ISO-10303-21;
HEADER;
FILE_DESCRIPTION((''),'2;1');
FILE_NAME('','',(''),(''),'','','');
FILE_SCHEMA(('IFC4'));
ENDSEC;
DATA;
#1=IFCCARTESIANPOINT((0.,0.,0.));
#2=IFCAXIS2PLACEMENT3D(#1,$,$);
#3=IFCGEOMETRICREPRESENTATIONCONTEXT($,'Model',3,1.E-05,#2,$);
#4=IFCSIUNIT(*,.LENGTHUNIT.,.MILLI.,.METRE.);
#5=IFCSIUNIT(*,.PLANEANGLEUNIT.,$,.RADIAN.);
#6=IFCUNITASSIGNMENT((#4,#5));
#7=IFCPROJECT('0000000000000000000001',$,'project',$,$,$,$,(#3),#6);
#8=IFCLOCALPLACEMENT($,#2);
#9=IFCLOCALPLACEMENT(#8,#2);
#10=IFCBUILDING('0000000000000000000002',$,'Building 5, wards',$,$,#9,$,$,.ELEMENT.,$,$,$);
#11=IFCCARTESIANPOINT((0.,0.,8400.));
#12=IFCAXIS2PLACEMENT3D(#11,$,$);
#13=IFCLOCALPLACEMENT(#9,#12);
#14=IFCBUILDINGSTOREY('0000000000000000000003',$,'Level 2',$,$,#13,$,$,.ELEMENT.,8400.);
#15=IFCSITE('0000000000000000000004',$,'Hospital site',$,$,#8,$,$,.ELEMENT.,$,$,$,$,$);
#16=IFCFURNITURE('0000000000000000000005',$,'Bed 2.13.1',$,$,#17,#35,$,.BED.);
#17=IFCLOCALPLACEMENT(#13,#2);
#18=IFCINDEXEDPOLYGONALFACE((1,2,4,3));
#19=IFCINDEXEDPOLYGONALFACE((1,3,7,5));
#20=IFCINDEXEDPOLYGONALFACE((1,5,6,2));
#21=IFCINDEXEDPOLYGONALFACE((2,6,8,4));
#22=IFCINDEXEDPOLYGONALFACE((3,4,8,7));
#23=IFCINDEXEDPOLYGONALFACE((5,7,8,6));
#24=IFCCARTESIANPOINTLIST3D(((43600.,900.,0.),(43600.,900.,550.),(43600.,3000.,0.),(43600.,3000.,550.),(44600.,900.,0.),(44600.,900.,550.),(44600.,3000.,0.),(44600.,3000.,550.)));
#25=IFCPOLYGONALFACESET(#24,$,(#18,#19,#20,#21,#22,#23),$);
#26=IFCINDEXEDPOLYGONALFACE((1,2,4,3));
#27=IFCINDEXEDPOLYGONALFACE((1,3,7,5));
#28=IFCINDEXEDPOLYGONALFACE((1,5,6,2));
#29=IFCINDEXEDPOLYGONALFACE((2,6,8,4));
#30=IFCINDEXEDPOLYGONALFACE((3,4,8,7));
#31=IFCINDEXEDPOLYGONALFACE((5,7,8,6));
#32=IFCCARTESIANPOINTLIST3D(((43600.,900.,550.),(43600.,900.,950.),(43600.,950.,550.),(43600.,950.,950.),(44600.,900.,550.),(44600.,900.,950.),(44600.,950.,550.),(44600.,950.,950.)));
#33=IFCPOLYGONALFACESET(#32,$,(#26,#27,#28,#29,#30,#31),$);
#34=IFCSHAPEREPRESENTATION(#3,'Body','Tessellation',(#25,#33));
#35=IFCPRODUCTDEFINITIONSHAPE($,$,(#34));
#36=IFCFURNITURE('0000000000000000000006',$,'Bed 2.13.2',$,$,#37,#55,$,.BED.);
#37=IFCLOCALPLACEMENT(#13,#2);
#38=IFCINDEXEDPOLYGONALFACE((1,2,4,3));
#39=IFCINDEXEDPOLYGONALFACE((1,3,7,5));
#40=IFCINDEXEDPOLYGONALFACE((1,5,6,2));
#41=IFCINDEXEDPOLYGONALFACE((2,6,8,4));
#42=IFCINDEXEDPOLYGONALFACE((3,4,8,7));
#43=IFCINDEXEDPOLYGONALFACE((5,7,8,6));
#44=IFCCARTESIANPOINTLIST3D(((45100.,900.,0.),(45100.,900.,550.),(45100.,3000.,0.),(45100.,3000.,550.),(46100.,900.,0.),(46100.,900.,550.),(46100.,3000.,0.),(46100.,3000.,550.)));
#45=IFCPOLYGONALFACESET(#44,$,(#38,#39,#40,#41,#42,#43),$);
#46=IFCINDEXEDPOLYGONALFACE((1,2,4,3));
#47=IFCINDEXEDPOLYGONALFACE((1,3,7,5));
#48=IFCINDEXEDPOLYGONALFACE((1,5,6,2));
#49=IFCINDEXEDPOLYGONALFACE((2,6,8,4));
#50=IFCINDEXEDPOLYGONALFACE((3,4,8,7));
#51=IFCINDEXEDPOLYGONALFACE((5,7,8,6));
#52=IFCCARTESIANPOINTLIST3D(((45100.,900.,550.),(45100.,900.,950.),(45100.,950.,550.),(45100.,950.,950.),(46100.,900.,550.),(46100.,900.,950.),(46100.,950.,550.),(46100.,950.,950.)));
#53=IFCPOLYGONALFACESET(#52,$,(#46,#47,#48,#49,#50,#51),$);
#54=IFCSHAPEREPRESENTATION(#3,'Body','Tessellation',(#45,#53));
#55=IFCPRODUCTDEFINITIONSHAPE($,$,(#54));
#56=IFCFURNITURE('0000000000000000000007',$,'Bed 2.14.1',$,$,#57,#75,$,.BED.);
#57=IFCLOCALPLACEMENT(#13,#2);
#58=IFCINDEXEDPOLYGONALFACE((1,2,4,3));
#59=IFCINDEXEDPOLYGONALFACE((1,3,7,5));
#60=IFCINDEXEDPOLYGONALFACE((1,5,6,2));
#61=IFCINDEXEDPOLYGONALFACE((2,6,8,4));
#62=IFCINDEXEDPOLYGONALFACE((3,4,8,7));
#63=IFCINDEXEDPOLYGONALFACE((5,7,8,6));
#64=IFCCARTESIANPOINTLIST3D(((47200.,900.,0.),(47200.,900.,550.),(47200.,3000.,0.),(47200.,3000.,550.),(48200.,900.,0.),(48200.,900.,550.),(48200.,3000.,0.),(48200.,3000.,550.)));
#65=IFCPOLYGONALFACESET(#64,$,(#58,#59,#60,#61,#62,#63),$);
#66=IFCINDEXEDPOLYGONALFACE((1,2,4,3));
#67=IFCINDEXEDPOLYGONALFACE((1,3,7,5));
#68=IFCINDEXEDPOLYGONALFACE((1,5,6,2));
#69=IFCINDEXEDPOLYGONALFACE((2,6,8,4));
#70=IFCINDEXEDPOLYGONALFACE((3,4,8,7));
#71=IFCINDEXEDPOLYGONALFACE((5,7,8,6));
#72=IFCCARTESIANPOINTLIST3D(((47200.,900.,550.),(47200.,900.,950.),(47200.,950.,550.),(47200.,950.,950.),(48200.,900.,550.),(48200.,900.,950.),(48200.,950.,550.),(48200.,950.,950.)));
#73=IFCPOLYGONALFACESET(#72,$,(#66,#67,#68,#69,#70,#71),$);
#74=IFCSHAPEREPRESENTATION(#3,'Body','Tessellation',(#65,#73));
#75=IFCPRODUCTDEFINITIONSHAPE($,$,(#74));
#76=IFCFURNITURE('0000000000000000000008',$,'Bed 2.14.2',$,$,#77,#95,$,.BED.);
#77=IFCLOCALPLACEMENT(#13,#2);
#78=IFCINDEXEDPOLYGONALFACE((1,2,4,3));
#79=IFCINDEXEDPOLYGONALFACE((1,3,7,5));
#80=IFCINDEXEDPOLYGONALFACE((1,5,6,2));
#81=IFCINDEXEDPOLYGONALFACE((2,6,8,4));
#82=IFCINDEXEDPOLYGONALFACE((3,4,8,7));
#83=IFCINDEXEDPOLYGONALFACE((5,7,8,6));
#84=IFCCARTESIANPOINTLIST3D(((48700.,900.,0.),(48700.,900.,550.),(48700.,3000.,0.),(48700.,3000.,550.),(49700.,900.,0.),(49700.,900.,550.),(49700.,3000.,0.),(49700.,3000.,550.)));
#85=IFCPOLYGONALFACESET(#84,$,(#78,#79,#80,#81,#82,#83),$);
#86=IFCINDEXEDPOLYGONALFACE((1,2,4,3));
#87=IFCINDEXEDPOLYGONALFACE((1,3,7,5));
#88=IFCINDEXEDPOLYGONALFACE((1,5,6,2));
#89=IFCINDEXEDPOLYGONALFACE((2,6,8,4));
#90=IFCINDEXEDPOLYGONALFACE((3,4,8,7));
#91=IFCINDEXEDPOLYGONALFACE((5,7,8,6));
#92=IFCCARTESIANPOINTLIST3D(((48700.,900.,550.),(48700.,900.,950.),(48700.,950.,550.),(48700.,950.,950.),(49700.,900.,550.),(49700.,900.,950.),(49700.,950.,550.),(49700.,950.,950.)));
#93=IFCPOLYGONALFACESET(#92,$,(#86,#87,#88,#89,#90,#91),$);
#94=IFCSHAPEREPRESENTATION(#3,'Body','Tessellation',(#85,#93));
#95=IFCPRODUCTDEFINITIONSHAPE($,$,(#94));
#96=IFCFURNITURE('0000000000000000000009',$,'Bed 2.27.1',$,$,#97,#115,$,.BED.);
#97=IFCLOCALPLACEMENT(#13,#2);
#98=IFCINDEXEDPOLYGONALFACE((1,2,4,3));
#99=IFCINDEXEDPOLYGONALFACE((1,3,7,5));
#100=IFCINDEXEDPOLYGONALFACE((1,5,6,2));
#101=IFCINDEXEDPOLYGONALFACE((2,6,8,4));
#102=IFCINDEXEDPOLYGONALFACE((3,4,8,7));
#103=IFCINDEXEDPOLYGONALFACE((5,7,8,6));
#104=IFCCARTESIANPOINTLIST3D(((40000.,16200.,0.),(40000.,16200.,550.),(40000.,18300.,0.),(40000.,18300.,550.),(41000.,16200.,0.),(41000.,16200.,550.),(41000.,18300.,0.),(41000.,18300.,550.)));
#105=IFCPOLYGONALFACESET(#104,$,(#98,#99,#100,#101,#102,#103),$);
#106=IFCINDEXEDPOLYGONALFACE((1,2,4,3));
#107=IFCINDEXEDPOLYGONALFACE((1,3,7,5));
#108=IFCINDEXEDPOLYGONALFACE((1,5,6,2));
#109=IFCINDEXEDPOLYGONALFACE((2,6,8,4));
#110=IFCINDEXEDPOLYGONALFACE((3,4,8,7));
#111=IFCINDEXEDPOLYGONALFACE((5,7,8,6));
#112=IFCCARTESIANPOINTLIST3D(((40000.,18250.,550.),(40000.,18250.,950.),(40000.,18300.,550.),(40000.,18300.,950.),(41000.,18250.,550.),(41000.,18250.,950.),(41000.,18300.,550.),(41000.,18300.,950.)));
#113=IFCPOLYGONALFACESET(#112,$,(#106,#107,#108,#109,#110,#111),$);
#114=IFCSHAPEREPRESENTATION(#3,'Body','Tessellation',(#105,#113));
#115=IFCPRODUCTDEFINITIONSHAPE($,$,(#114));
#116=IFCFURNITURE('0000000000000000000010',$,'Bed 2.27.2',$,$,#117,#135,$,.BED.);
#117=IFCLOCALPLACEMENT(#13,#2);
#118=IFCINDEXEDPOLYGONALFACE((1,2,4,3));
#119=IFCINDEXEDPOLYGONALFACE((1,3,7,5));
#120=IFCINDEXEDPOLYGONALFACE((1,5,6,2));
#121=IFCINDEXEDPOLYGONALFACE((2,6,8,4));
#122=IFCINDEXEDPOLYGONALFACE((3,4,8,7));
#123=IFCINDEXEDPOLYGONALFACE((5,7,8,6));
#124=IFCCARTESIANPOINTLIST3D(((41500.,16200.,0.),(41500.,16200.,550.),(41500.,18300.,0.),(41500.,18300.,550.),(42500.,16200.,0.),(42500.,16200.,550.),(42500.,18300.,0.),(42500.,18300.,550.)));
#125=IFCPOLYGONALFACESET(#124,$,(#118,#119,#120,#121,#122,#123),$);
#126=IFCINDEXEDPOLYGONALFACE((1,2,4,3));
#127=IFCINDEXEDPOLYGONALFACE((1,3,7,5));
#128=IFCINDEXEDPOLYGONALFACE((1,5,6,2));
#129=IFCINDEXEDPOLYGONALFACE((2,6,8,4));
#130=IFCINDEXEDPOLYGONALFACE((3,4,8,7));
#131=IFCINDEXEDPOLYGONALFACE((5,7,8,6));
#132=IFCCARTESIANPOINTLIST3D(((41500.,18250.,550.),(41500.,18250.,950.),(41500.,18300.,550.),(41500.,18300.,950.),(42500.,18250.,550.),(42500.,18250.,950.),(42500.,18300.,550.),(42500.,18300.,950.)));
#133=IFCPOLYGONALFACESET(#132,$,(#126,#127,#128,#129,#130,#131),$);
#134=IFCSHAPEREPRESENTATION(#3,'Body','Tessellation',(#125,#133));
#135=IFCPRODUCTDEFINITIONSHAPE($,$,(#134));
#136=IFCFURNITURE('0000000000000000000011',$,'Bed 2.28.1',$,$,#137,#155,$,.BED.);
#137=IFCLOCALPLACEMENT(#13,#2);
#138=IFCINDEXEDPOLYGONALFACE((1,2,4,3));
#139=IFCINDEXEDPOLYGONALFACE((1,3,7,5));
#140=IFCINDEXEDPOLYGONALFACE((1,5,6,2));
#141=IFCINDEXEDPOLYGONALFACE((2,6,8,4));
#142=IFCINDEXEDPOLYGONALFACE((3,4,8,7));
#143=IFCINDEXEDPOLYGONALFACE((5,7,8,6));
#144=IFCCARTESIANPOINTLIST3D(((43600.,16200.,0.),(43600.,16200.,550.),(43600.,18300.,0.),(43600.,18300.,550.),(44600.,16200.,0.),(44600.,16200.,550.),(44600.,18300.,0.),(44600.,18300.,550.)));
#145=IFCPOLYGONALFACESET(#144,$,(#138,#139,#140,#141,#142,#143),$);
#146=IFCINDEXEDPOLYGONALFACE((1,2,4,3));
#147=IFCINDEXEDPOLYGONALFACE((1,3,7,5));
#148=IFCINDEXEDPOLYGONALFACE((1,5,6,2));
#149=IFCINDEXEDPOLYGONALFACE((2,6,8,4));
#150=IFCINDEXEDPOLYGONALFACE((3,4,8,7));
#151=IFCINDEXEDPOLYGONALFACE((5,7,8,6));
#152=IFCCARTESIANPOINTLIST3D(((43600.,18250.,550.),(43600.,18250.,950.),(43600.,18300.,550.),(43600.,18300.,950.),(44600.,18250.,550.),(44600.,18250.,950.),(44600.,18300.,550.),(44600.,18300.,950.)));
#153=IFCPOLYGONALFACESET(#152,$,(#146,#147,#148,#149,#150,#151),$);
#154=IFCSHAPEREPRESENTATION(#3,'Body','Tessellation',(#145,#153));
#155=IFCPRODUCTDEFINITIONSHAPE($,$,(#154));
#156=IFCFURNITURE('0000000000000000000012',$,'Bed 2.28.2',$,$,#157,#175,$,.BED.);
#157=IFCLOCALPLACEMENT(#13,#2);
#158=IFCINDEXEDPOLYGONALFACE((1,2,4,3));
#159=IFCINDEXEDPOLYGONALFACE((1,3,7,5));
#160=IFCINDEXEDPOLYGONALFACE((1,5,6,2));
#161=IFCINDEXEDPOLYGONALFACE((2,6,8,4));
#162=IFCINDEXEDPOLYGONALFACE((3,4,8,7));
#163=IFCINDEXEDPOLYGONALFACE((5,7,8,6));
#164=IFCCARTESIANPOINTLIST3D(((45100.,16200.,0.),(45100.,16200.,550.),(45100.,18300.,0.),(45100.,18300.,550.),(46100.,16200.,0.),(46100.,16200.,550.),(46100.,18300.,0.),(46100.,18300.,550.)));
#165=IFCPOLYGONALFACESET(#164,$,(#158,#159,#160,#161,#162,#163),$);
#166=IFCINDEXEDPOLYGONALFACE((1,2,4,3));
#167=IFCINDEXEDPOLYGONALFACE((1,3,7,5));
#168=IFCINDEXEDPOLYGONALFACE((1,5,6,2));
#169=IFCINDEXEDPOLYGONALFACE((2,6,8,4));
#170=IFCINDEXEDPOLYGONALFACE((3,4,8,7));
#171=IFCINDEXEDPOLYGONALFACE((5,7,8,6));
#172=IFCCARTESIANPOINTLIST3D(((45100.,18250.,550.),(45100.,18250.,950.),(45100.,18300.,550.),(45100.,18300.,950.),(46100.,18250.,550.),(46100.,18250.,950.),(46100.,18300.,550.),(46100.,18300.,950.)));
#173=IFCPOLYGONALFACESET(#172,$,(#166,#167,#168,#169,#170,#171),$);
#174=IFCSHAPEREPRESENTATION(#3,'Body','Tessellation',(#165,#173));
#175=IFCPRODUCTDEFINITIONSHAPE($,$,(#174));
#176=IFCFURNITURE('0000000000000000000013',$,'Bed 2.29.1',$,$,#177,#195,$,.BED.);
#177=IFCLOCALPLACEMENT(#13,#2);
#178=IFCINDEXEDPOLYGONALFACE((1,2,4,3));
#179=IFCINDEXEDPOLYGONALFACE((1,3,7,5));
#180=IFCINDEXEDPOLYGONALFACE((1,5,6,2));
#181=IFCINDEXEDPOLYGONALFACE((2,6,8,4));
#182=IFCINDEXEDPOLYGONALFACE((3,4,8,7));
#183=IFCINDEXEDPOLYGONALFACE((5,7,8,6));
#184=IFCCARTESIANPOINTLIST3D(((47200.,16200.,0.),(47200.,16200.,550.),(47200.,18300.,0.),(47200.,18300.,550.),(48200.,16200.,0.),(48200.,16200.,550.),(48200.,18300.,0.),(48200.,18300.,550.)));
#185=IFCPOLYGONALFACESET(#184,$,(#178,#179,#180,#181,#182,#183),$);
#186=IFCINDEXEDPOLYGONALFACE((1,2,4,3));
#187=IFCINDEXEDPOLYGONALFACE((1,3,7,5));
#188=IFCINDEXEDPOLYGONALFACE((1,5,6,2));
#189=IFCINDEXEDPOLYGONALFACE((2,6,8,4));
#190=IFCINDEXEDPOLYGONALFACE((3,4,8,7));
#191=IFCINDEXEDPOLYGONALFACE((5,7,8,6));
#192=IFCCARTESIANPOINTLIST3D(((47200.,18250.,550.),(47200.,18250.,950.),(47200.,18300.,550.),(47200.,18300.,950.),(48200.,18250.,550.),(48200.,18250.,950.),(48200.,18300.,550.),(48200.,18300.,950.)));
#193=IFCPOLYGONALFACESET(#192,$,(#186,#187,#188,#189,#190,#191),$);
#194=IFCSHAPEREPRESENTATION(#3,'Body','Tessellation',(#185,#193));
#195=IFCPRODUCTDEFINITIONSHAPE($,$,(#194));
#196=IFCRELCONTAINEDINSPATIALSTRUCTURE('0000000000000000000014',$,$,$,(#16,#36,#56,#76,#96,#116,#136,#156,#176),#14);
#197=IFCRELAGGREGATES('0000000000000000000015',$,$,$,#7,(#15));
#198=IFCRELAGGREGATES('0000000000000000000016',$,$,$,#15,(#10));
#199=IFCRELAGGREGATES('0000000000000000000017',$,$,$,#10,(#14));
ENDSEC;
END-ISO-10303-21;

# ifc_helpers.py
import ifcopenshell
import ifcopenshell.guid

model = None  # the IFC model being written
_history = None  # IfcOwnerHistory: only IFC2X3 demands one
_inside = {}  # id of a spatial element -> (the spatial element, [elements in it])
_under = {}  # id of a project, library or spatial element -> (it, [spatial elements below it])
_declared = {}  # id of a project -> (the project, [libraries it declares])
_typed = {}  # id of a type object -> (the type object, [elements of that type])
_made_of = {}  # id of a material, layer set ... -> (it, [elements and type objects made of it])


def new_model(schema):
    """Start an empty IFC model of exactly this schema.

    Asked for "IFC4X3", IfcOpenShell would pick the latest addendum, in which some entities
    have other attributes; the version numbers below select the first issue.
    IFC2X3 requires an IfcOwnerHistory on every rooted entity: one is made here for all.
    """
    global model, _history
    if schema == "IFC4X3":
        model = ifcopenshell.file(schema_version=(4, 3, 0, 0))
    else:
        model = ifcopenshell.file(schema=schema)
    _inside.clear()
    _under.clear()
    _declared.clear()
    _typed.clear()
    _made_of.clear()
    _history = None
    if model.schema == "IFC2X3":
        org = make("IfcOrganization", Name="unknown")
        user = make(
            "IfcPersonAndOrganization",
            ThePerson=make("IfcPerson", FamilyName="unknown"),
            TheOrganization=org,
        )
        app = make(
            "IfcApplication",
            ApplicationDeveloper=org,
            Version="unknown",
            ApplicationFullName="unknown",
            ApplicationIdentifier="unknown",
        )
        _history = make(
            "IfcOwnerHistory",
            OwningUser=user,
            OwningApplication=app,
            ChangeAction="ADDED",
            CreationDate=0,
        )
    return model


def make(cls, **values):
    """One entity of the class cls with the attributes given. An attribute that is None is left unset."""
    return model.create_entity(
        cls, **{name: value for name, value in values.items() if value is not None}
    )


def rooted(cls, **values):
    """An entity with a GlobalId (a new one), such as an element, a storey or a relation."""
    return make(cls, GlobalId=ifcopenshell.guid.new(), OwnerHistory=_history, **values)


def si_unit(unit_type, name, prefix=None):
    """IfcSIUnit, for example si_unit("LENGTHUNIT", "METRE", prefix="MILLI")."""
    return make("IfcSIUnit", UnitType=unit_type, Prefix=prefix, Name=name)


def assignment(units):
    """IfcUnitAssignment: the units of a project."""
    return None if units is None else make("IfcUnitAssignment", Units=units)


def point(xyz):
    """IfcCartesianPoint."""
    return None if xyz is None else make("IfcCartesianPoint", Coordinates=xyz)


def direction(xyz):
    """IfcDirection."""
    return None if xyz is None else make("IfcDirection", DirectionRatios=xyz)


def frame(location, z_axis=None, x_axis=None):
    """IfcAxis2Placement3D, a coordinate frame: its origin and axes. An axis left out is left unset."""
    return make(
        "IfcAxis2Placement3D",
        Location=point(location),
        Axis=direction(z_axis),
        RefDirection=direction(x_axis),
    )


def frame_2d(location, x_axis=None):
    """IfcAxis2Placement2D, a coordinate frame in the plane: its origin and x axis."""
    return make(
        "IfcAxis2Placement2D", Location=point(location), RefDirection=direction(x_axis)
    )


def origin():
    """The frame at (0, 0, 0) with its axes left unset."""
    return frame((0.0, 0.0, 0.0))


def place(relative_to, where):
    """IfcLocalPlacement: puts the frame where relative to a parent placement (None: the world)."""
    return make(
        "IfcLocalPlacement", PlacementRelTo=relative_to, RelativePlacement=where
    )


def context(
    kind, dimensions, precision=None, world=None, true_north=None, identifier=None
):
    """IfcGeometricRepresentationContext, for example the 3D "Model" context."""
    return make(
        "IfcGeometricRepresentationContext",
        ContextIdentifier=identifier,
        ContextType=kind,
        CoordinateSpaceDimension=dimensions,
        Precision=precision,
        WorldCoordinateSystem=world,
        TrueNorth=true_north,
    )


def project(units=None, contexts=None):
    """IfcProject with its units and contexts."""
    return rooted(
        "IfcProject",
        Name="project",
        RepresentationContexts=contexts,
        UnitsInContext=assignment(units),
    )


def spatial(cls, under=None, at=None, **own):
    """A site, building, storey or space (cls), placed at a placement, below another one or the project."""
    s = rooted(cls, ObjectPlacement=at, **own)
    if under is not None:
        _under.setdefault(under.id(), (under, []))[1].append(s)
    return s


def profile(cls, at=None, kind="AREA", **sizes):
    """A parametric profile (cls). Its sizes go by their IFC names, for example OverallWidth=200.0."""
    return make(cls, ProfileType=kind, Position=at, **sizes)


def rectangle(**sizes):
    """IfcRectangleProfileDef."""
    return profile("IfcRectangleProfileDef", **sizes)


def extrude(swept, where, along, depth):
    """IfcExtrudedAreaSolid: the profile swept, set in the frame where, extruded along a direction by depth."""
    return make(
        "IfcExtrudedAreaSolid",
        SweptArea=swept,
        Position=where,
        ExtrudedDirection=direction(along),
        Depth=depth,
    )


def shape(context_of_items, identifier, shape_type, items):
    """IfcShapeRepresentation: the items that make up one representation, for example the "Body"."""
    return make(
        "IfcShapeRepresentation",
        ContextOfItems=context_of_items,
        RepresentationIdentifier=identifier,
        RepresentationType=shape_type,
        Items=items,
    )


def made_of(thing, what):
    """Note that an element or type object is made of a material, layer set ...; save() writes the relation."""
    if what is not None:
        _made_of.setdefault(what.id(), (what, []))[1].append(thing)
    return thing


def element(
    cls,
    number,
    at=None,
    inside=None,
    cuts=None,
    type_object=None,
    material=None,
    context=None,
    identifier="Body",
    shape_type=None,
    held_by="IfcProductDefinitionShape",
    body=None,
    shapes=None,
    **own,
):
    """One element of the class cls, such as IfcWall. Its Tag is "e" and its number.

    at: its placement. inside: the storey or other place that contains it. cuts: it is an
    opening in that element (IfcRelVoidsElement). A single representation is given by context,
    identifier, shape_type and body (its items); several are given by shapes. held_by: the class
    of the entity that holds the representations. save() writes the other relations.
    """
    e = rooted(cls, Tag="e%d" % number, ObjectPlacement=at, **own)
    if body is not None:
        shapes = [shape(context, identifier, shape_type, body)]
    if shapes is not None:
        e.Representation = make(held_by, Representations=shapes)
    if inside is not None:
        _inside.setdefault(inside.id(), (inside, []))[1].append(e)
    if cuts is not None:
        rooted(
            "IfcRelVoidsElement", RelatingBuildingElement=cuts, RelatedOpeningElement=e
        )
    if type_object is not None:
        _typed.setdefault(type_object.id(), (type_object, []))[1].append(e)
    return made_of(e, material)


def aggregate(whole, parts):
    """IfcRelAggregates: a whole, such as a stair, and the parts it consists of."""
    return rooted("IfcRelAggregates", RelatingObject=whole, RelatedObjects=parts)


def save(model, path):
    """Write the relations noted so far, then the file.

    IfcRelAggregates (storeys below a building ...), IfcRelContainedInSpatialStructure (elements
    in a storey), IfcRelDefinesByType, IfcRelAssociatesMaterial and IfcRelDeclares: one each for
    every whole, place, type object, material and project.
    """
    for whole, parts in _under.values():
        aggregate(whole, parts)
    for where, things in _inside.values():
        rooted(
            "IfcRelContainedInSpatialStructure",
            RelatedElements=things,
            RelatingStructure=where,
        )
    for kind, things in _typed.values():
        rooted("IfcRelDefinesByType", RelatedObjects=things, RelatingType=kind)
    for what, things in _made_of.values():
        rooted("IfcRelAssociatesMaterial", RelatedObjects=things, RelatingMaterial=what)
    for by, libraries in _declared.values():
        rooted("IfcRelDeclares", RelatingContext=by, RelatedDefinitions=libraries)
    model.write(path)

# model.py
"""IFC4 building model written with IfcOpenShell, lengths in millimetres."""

from ifc_helpers import new_model, si_unit, frame, frame_2d, origin, place, context, project, spatial, rectangle, extrude, element, save


model = new_model("IFC4")

# Units and contexts
model_context = context("Model", 3, precision=1e-05, world=origin())
ifc_project = project(units=[si_unit("LENGTHUNIT", "METRE", prefix="MILLI"), si_unit("PLANEANGLEUNIT", "RADIAN")], contexts=[model_context])

# Site, building, storey
site_placement = place(None, origin())
site = spatial("IfcSite", under=ifc_project, at=site_placement, Name="Hospital site", CompositionType="ELEMENT")
building_placement = place(site_placement, origin())
building = spatial("IfcBuilding", under=site, at=building_placement, Name="Building 5, wards", CompositionType="ELEMENT")
storey_placement = place(building_placement, frame((0.0, 0.0, 8400.0)))
storey = spatial("IfcBuildingStorey", under=building, at=storey_placement, Name="Level 2", CompositionType="ELEMENT", Elevation=8400.0)

# Furniture
for number, where, name in (
    (1, (43600.0, 900.0, 0.0), "Bed 2.13.1"),
    (2, (45100.0, 900.0, 0.0), "Bed 2.13.2"),
    (3, (47200.0, 900.0, 0.0), "Bed 2.14.1"),
    (4, (48700.0, 900.0, 0.0), "Bed 2.14.2"),
):
    element("IfcFurniture", number, at=place(storey_placement, frame(where)), inside=storey, Name=name, PredefinedType="BED", context=model_context, shape_type="SweptSolid", body=[
        extrude(rectangle(XDim=1000.0, YDim=2100.0, at=frame_2d((500.0, 1050.0))), origin(), (0.0, 0.0, 1.0), 550.0),
        extrude(rectangle(XDim=1000.0, YDim=50.0, at=frame_2d((500.0, 25.0))), frame((0.0, 0.0, 550.0)), (0.0, 0.0, 1.0), 400.0),
    ])
for number, where, name in (
    (5, (40000.0, 16200.0, 0.0), "Bed 2.27.1"),
    (6, (41500.0, 16200.0, 0.0), "Bed 2.27.2"),
    (7, (43600.0, 16200.0, 0.0), "Bed 2.28.1"),
    (8, (45100.0, 16200.0, 0.0), "Bed 2.28.2"),
    (9, (47200.0, 16200.0, 0.0), "Bed 2.29.1"),
):
    element("IfcFurniture", number, at=place(storey_placement, frame(where)), inside=storey, Name=name, PredefinedType="BED", context=model_context, shape_type="SweptSolid", body=[
        extrude(rectangle(XDim=1000.0, YDim=2100.0, at=frame_2d((500.0, 1050.0))), origin(), (0.0, 0.0, 1.0), 550.0),
        extrude(rectangle(XDim=1000.0, YDim=50.0, at=frame_2d((500.0, 2075.0))), frame((0.0, 0.0, 550.0)), (0.0, 0.0, 1.0), 400.0),
    ])

save(model, "model.ifc")
